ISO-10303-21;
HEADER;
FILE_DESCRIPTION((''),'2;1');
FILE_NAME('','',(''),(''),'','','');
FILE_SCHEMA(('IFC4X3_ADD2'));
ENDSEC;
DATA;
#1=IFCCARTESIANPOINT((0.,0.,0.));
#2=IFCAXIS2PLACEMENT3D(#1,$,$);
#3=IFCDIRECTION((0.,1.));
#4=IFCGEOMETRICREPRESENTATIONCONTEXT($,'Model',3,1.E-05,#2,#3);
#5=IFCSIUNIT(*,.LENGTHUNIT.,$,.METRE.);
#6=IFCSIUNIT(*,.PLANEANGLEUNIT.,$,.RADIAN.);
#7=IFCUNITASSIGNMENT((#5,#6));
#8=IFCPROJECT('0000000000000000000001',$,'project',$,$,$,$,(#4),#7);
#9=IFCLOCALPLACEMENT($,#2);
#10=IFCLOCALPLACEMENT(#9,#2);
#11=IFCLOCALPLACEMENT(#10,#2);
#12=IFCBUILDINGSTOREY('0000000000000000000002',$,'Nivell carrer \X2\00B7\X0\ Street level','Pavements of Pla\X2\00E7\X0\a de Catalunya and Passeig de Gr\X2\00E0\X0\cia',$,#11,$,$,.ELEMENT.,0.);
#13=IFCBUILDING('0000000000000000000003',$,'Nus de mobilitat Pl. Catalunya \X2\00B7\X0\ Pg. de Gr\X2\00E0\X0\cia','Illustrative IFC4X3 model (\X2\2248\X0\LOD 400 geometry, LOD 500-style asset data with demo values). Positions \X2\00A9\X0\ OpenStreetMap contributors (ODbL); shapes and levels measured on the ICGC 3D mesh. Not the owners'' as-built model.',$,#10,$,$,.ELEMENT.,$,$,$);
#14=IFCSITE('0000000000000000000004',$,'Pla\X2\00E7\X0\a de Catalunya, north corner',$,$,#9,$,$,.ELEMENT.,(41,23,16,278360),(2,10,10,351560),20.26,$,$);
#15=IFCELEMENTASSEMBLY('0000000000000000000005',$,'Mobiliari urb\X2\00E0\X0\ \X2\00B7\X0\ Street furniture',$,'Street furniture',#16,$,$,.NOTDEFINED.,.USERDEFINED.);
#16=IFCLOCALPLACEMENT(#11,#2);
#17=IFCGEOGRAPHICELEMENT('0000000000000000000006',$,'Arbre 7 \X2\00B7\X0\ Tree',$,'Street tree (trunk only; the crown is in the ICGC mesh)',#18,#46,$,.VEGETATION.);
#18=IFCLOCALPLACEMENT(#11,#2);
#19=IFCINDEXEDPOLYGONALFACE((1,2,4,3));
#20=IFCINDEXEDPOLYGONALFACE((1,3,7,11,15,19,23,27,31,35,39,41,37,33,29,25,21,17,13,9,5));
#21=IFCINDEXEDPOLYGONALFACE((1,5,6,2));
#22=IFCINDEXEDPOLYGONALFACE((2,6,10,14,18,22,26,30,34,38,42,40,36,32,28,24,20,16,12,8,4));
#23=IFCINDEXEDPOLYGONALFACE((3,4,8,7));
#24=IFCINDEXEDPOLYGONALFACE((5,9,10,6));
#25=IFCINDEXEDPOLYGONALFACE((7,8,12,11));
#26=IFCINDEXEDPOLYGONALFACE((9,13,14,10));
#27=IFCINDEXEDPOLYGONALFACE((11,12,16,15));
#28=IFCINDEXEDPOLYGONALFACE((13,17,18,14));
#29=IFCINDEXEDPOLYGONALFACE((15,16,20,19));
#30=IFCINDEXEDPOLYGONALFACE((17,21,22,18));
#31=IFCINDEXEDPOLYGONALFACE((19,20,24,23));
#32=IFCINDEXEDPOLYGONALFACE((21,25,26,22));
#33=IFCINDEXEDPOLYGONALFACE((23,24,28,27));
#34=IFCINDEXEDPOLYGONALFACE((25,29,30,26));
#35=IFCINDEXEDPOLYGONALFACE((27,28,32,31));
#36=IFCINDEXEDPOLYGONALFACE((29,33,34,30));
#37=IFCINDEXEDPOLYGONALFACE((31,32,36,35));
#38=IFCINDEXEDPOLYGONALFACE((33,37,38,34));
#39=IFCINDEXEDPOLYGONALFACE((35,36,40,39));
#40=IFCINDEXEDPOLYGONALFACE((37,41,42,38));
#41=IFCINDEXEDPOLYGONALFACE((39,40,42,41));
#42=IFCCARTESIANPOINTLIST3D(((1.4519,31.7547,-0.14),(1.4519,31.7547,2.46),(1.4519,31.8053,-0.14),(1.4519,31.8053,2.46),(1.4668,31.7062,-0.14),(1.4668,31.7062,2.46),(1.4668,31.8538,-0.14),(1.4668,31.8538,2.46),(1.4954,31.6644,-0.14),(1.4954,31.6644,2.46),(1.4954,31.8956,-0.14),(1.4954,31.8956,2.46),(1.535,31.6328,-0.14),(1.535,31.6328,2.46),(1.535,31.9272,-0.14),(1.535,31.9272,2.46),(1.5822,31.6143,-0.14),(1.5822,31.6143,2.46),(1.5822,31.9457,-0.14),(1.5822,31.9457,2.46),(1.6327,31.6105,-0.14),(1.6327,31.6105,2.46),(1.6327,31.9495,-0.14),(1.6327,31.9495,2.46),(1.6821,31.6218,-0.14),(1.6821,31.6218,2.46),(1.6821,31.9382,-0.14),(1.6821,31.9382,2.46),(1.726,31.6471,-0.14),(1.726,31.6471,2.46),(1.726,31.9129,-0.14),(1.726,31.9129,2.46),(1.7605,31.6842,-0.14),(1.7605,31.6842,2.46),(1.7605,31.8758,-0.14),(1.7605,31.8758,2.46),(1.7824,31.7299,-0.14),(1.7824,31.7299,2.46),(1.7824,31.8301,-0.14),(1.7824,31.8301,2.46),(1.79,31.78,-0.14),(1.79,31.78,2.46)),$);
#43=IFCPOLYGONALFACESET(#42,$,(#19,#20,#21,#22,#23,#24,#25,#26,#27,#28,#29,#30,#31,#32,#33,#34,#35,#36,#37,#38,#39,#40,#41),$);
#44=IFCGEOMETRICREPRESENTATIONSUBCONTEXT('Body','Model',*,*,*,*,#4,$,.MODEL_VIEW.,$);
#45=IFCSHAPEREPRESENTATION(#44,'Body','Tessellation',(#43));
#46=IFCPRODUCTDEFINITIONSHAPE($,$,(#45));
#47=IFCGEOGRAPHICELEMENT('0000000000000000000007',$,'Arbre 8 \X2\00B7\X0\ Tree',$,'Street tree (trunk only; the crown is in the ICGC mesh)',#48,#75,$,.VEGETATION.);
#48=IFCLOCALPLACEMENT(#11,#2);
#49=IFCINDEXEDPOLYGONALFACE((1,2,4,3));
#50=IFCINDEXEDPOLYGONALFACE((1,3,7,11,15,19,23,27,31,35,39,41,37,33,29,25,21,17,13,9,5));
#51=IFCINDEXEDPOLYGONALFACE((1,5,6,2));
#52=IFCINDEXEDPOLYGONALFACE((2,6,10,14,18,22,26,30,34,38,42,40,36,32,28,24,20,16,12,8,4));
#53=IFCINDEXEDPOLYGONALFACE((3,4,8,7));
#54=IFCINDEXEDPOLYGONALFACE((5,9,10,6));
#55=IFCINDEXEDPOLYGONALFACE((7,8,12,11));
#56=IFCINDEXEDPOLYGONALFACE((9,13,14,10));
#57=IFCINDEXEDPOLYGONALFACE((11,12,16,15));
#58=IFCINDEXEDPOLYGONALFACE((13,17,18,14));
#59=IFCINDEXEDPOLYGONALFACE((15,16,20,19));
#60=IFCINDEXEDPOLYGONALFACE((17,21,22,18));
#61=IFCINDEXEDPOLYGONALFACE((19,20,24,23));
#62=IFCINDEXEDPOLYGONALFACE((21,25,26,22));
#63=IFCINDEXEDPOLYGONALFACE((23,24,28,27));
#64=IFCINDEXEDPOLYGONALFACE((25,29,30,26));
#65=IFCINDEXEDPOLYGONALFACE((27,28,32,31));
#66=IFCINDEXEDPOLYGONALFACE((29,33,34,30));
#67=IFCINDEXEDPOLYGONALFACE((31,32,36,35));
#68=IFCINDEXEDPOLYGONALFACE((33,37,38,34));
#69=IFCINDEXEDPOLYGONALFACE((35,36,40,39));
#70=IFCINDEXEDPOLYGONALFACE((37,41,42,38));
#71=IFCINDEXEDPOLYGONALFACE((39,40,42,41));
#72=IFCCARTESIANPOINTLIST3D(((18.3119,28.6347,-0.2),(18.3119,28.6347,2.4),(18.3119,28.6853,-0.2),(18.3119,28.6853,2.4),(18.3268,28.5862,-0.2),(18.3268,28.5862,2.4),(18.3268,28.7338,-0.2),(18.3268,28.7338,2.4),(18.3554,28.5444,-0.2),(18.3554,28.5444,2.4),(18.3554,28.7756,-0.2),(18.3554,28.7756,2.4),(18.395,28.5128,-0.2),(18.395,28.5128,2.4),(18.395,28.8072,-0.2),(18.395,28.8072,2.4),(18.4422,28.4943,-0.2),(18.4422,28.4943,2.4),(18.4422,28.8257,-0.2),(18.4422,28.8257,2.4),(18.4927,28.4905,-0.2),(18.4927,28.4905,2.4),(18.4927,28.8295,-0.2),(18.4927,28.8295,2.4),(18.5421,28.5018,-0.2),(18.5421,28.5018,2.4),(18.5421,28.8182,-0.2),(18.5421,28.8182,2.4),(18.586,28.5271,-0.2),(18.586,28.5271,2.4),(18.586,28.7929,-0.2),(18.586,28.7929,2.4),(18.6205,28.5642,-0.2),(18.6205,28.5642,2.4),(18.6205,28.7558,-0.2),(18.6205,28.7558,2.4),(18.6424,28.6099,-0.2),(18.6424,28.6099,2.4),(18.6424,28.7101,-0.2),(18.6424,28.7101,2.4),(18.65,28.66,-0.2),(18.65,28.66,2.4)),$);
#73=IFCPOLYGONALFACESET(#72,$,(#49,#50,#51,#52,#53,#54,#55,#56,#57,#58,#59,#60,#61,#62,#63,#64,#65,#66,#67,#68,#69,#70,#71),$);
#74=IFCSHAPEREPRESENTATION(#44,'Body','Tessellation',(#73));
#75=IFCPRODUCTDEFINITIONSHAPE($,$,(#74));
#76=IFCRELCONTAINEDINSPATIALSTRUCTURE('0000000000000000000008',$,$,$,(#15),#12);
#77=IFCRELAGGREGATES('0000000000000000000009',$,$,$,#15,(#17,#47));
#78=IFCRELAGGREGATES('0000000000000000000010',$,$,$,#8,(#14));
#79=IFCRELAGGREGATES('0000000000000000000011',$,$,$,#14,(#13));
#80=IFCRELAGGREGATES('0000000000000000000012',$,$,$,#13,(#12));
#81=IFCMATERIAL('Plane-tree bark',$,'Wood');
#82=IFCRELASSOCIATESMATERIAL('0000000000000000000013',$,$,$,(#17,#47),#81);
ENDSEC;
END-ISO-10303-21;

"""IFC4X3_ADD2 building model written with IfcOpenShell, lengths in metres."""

from ifc_helpers import new_model, si_unit, direction, frame, origin, origin_2d_with_axis, place, context, subcontext, project, spatial, circle, extrude, material, element, aggregate, save


model = new_model("IFC4X3_ADD2")

# Units and contexts
model_context = context("Model", 3, precision=1e-05, world=origin(), true_north=direction((0.0, 1.0)))
body_context = subcontext(model_context, "Body", "Model", "MODEL_VIEW")
ifc_project = project(units=[si_unit("LENGTHUNIT", "METRE"), si_unit("PLANEANGLEUNIT", "RADIAN")], contexts=[model_context])

# Site, building, storey
site_placement = place(None, origin())
site = spatial("IfcSite", under=ifc_project, at=site_placement, Name="Plaça de Catalunya, north corner", CompositionType="ELEMENT", RefLatitude=(41, 23, 16, 278360), RefLongitude=(2, 10, 10, 351560), RefElevation=20.26)
building_placement = place(site_placement, origin())
building = spatial("IfcBuilding", under=site, at=building_placement, Name="Nus de mobilitat Pl. Catalunya · Pg. de Gràcia", Description="Illustrative IFC4X3 model (≈LOD 400 geometry, LOD 500-style asset data with demo values). Positions © OpenStreetMap contributors (ODbL); shapes and levels measured on the ICGC 3D mesh. Not the owners' as-built model.", CompositionType="ELEMENT")
storey_placement = place(building_placement, origin())
storey = spatial("IfcBuildingStorey", under=building, at=storey_placement, Name="Nivell carrer · Street level", Description="Pavements of Plaça de Catalunya and Passeig de Gràcia", CompositionType="ELEMENT", Elevation=0.0)

# Element assembly
assembly_1_placement = place(building_placement, origin())
assembly_1 = element("IfcElementAssembly", 1, at=assembly_1_placement, inside=storey, Name="Mobiliari urbà · Street furniture", ObjectType="Street furniture", AssemblyPlace="NOTDEFINED", PredefinedType="USERDEFINED")

# Geographic elements
ifc_material_1 = material(Name="Plane-tree bark", Category="Wood")
geographic_element_1_placement = place(building_placement, origin())
geographic_element_1 = element("IfcGeographicElement", 2, at=geographic_element_1_placement, material=ifc_material_1, Name="Arbre 7 · Tree", ObjectType="Street tree (trunk only; the crown is in the ICGC mesh)", PredefinedType="VEGETATION", context=body_context, shape_type="SweptSolid", body=[
    extrude(circle(Radius=0.17, at=origin_2d_with_axis()), frame((1.62, 31.78, -0.14)), (0.0, 0.0, 1.0), 2.6),
])
geographic_element_2_placement = place(building_placement, origin())
geographic_element_2 = element("IfcGeographicElement", 3, at=geographic_element_2_placement, material=ifc_material_1, Name="Arbre 8 · Tree", ObjectType="Street tree (trunk only; the crown is in the ICGC mesh)", PredefinedType="VEGETATION", context=body_context, shape_type="SweptSolid", body=[
    extrude(circle(Radius=0.17, at=origin_2d_with_axis()), frame((18.48, 28.66, -0.2)), (0.0, 0.0, 1.0), 2.6),
])
aggregate(assembly_1, [geographic_element_1, geographic_element_2])

save(model, "model.ifc")
